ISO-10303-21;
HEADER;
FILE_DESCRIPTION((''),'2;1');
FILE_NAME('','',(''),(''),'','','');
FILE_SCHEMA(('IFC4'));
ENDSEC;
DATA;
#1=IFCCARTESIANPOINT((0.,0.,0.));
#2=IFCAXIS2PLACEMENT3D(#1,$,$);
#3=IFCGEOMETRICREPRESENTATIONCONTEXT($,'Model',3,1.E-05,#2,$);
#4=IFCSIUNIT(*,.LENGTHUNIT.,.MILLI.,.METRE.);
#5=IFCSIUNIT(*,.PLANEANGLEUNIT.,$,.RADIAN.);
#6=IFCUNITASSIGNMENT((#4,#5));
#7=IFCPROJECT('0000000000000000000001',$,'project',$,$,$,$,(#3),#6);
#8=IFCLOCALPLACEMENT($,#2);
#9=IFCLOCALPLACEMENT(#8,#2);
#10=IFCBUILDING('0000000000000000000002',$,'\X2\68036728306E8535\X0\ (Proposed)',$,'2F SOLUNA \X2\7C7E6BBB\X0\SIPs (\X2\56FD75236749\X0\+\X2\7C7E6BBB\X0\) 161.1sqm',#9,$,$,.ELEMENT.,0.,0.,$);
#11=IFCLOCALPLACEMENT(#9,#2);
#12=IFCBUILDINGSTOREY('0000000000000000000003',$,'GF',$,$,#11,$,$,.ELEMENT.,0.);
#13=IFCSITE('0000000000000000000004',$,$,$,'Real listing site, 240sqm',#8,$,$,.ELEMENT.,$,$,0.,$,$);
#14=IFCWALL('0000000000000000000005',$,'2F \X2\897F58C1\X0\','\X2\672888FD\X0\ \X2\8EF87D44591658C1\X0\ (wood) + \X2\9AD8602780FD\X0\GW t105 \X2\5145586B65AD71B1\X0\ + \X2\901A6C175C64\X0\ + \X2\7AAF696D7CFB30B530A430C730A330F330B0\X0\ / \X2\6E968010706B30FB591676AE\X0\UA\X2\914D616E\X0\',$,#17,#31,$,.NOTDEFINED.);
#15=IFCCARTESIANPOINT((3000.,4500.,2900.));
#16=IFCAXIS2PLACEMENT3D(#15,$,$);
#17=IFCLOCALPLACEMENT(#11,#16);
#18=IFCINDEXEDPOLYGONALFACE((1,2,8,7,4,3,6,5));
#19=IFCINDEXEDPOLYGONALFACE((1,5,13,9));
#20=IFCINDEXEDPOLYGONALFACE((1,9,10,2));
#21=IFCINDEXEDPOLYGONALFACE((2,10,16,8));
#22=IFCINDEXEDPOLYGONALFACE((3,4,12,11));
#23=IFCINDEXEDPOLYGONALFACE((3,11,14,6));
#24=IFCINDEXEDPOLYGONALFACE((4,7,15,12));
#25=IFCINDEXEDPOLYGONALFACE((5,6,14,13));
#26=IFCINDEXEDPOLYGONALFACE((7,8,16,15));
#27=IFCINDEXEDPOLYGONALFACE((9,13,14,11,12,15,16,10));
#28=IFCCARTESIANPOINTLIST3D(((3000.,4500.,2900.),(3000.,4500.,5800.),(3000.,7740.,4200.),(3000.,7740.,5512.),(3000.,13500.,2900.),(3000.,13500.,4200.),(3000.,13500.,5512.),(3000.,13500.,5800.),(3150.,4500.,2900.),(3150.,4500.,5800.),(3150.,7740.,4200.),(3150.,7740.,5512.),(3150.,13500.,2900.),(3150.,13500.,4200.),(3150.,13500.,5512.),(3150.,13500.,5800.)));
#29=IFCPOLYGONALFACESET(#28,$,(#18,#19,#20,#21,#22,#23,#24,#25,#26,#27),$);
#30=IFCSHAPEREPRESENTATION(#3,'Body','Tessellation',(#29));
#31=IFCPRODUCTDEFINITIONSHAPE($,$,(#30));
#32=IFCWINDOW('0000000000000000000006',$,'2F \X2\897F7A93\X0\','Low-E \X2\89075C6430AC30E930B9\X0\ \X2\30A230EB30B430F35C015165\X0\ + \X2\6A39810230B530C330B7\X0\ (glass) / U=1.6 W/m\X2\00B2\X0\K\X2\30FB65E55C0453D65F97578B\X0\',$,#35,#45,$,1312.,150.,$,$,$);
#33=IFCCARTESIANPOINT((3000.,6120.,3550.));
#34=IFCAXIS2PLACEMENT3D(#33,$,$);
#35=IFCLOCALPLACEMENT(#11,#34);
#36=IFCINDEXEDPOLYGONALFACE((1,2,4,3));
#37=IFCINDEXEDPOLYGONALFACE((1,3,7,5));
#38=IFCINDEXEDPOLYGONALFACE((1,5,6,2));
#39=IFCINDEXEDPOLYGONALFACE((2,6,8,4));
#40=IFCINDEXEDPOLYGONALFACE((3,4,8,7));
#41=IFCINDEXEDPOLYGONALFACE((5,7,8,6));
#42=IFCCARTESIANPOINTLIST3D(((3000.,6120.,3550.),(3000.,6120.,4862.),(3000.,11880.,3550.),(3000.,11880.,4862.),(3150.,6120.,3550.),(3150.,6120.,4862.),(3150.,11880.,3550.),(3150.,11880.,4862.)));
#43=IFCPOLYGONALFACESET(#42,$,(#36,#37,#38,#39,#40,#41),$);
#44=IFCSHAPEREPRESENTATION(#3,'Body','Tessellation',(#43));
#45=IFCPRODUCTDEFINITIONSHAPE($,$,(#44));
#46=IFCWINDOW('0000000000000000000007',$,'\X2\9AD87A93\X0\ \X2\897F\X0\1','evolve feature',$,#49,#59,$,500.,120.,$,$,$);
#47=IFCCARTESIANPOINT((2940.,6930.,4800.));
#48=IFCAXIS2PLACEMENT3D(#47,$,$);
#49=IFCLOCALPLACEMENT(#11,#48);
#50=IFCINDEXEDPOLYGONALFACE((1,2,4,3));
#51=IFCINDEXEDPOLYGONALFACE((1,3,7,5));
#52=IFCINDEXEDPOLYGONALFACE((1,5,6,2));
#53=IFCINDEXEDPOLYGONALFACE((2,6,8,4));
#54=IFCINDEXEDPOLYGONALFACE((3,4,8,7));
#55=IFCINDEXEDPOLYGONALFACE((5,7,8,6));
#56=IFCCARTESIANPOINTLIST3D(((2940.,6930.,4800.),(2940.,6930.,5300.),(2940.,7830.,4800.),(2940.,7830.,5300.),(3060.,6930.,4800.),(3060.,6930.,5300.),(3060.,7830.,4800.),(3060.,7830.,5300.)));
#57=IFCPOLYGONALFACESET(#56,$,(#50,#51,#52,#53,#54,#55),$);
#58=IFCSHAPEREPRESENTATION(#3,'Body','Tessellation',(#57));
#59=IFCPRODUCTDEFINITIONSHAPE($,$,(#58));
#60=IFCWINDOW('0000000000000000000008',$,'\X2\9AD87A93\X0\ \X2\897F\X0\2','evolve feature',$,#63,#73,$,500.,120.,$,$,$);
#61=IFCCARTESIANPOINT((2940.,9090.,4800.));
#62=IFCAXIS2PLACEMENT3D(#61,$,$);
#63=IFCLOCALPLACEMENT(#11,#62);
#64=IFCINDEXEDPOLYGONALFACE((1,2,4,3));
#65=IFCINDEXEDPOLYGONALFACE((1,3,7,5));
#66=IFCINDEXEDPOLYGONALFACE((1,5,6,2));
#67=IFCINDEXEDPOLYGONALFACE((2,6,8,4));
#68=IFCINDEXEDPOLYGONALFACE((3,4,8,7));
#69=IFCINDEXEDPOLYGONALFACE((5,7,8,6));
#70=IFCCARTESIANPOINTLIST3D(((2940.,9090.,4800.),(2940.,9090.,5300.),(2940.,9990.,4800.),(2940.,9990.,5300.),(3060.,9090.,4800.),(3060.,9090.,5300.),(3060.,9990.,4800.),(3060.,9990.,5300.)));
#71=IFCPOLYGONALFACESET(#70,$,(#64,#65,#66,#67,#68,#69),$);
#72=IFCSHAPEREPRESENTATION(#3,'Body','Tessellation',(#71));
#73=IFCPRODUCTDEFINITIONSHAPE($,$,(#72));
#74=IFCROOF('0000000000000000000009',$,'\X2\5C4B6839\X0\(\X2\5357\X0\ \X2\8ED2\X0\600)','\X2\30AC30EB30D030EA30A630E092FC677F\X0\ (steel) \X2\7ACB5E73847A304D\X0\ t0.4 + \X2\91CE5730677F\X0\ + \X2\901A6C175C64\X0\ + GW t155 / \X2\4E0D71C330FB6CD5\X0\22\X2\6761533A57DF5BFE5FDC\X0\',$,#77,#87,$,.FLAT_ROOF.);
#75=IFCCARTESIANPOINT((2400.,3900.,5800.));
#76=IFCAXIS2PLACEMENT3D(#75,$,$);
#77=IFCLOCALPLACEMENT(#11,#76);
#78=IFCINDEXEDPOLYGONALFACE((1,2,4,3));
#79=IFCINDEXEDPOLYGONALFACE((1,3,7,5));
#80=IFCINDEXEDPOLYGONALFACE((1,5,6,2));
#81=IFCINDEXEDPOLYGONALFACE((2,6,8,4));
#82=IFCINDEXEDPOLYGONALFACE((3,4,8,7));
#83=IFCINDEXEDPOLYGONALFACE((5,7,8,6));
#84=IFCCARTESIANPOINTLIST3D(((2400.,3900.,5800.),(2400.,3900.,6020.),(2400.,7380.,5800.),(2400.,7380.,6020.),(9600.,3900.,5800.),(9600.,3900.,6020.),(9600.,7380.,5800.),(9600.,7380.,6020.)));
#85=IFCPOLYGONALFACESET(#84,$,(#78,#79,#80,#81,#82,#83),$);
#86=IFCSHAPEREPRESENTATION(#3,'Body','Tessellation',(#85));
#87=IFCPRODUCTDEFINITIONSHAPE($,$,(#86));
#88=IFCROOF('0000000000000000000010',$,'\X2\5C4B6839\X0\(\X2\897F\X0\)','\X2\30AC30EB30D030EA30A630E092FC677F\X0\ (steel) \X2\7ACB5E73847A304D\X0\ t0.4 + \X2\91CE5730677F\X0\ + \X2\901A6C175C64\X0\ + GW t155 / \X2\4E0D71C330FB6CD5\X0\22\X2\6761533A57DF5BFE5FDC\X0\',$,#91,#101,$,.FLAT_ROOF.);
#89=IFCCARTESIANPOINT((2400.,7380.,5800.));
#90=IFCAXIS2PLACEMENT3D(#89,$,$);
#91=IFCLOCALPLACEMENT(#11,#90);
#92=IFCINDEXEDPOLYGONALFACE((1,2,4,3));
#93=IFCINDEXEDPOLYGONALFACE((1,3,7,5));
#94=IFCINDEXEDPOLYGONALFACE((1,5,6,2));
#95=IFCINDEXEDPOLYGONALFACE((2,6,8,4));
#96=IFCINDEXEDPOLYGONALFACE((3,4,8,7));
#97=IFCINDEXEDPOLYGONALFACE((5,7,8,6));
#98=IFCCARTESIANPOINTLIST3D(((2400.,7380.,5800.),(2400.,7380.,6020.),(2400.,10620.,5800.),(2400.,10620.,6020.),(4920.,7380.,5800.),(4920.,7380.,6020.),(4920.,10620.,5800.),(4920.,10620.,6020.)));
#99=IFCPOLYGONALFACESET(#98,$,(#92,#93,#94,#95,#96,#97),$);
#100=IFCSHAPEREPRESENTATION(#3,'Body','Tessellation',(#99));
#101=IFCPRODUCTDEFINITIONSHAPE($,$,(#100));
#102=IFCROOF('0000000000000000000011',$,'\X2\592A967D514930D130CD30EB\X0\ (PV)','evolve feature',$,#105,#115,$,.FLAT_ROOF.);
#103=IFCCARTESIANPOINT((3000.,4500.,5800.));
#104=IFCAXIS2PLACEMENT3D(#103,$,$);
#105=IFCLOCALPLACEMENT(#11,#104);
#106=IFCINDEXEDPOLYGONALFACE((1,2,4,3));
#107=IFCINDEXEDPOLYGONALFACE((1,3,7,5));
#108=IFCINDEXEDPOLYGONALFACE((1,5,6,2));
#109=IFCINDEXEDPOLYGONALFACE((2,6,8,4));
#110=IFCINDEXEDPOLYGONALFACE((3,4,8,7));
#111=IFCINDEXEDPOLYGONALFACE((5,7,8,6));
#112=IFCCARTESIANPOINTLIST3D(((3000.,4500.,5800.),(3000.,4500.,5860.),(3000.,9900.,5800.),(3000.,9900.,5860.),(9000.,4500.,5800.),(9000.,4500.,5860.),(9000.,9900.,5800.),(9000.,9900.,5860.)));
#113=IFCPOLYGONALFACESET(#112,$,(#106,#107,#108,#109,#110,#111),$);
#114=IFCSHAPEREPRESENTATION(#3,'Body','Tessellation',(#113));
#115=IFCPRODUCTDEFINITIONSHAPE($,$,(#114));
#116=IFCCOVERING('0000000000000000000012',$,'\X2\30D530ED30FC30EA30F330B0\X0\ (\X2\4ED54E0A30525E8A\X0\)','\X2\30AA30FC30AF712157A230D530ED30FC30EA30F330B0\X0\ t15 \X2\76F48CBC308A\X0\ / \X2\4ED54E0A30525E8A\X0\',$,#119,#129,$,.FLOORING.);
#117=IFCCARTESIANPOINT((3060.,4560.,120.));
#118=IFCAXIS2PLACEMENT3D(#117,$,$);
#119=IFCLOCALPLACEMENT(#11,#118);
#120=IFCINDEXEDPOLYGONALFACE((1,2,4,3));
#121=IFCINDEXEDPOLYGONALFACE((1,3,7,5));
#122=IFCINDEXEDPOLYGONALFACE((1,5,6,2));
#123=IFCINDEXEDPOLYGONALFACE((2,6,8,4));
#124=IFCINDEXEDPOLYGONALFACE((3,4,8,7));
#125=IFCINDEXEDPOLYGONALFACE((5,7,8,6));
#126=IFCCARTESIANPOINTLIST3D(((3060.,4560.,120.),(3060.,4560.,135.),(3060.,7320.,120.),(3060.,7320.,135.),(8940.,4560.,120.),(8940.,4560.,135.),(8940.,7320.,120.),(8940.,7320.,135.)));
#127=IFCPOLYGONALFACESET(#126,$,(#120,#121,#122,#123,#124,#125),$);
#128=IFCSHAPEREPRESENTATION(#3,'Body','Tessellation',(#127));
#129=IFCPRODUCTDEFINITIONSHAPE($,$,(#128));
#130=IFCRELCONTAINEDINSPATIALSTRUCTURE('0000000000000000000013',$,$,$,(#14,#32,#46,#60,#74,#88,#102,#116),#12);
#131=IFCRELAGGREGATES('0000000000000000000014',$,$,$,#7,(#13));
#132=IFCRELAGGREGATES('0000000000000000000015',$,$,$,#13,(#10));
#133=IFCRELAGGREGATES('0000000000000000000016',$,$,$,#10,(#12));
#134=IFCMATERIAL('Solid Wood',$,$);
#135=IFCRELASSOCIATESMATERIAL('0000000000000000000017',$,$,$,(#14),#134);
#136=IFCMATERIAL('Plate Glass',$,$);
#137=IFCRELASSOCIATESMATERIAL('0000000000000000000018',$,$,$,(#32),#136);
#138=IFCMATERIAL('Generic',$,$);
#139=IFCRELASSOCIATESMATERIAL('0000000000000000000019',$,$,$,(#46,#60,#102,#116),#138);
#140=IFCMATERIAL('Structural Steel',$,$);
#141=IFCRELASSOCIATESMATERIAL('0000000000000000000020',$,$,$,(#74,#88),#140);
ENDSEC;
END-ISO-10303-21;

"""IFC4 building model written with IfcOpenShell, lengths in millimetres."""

from ifc_helpers import new_model, si_unit, frame, frame_2d, origin, place, context, project, spatial, rectangle, extrude, material, element, fill, save


model = new_model("IFC4")

# Units and contexts
model_context = context("Model", 3, precision=1e-05, world=origin())
ifc_project = project(units=[si_unit("LENGTHUNIT", "METRE", prefix="MILLI"), si_unit("PLANEANGLEUNIT", "RADIAN")], contexts=[model_context])

# Site, building, storey
site_placement = place(None, origin())
site = spatial("IfcSite", under=ifc_project, at=site_placement, ObjectType="Real listing site, 240sqm", CompositionType="ELEMENT", RefElevation=0.0)
building_placement = place(site_placement, origin())
building = spatial("IfcBuilding", under=site, at=building_placement, Name="栃木の蔵 (Proposed)", ObjectType="2F SOLUNA 籾殻SIPs (国産杉+籾殻) 161.1sqm", CompositionType="ELEMENT", ElevationOfRefHeight=0.0, ElevationOfTerrain=0.0)
storey_placement = place(building_placement, origin())
storey = spatial("IfcBuildingStorey", under=building, at=storey_placement, Name="GF", CompositionType="ELEMENT", Elevation=0.0)

# Shared definitions
ifc_material_1 = material(Name="Solid Wood")
ifc_material_2 = material(Name="Generic")

# Shared definitions
ifc_material_3 = material(Name="Plate Glass")

# Wall, openings, windows
wall_1_placement = place(storey_placement, frame((3000.0, 4500.0, 2900.0)))
wall_1 = element("IfcWall", 1, at=wall_1_placement, inside=storey, material=ifc_material_1, Name="2F 西壁", Description="木製 軸組外壁 (wood) + 高性能GW t105 充填断熱 + 通気層 + 窯業系サイディング / 準耐火・外皮UA配慮", PredefinedType="NOTDEFINED", context=model_context, shape_type="SweptSolid", body=[
    extrude(rectangle(XDim=150.0, YDim=9000.0, at=frame_2d((75.0, 4500.0))), frame((3000.0, 4500.0, 2900.0)), (0.0, 0.0, 1.0), 2900.0),
])
opening_1_placement = place(storey_placement, frame((3000.0, 6120.0, 3550.0)))
opening_1 = element("IfcOpeningElement", 2, at=opening_1_placement, cuts=wall_1, PredefinedType="NOTDEFINED", context=model_context, shape_type="SweptSolid", body=[
    extrude(rectangle(XDim=150.0, YDim=5760.0, at=frame_2d((75.0, 2880.0))), frame((3000.0, 6120.0, 3550.0)), (0.0, 0.0, 1.0), 1312.0),
])
opening_2_placement = place(storey_placement, frame((2940.0, 6930.0, 4800.0)))
opening_2 = element("IfcOpeningElement", 3, at=opening_2_placement, cuts=wall_1, PredefinedType="NOTDEFINED", context=model_context, shape_type="SweptSolid", body=[
    extrude(rectangle(XDim=120.0, YDim=900.0, at=frame_2d((60.0, 450.0))), frame((2940.0, 6930.0, 4800.0)), (0.0, 0.0, 1.0), 500.0),
])
opening_3_placement = place(storey_placement, frame((2940.0, 9090.0, 4800.0)))
opening_3 = element("IfcOpeningElement", 4, at=opening_3_placement, cuts=wall_1, PredefinedType="NOTDEFINED", context=model_context, shape_type="SweptSolid", body=[
    extrude(rectangle(XDim=120.0, YDim=900.0, at=frame_2d((60.0, 450.0))), frame((2940.0, 9090.0, 4800.0)), (0.0, 0.0, 1.0), 500.0),
])
window_1_placement = place(storey_placement, frame((3000.0, 6120.0, 3550.0)))
window_1 = element("IfcWindow", 5, at=window_1_placement, inside=storey, material=ifc_material_3, Name="2F 西窓", Description="Low-E 複層ガラス アルゴン封入 + 樹脂サッシ (glass) / U=1.6 W/m²K・日射取得型", OverallHeight=1312.0, OverallWidth=150.0, context=model_context, shape_type="SweptSolid", body=[
    extrude(rectangle(XDim=150.0, YDim=5760.0, at=frame_2d((75.0, 2880.0))), frame((3000.0, 6120.0, 3550.0)), (0.0, 0.0, 1.0), 1312.0),
])
fill(opening_1, window_1)
window_2_placement = place(storey_placement, frame((2940.0, 6930.0, 4800.0)))
window_2 = element("IfcWindow", 6, at=window_2_placement, inside=storey, material=ifc_material_2, Name="高窓 西1", Description="evolve feature", OverallHeight=500.0, OverallWidth=120.0, context=model_context, shape_type="SweptSolid", body=[
    extrude(rectangle(XDim=120.0, YDim=900.0, at=frame_2d((60.0, 450.0))), frame((2940.0, 6930.0, 4800.0)), (0.0, 0.0, 1.0), 500.0),
])
fill(opening_2, window_2)
window_3_placement = place(storey_placement, frame((2940.0, 9090.0, 4800.0)))
window_3 = element("IfcWindow", 7, at=window_3_placement, inside=storey, material=ifc_material_2, Name="高窓 西2", Description="evolve feature", OverallHeight=500.0, OverallWidth=120.0, context=model_context, shape_type="SweptSolid", body=[
    extrude(rectangle(XDim=120.0, YDim=900.0, at=frame_2d((60.0, 450.0))), frame((2940.0, 9090.0, 4800.0)), (0.0, 0.0, 1.0), 500.0),
])
fill(opening_3, window_3)

# Roofs
ifc_material_4 = material(Name="Structural Steel")
roof_1_placement = place(storey_placement, frame((2400.0, 3900.0, 5800.0)))
element("IfcRoof", 8, at=roof_1_placement, inside=storey, material=ifc_material_4, Name="屋根(南 軒600)", Description="ガルバリウム鋼板 (steel) 立平葺き t0.4 + 野地板 + 通気層 + GW t155 / 不燃・法22条区域対応", PredefinedType="FLAT_ROOF", context=model_context, shape_type="SweptSolid", body=[
    extrude(rectangle(XDim=7200.0, YDim=3480.0, at=frame_2d((3600.0, 1740.0))), frame((2400.0, 3900.0, 5800.0)), (0.0, 0.0, 1.0), 220.0),
])
roof_2_placement = place(storey_placement, frame((2400.0, 7380.0, 5800.0)))
element("IfcRoof", 9, at=roof_2_placement, inside=storey, material=ifc_material_4, Name="屋根(西)", Description="ガルバリウム鋼板 (steel) 立平葺き t0.4 + 野地板 + 通気層 + GW t155 / 不燃・法22条区域対応", PredefinedType="FLAT_ROOF", context=model_context, shape_type="SweptSolid", body=[
    extrude(rectangle(XDim=2520.0, YDim=3240.0, at=frame_2d((1260.0, 1620.0))), frame((2400.0, 7380.0, 5800.0)), (0.0, 0.0, 1.0), 220.0),
])
roof_3_placement = place(storey_placement, frame((3000.0, 4500.0, 5800.0)))
element("IfcRoof", 10, at=roof_3_placement, inside=storey, material=ifc_material_2, Name="太陽光パネル (PV)", Description="evolve feature", PredefinedType="FLAT_ROOF", context=model_context, shape_type="SweptSolid", body=[
    extrude(rectangle(XDim=6000.0, YDim=5400.0, at=frame_2d((3000.0, 2700.0))), frame((3000.0, 4500.0, 5800.0)), (0.0, 0.0, 1.0), 60.0),
])

# Covering
covering_placement = place(storey_placement, frame((3060.0, 4560.0, 120.0)))
element("IfcCovering", 11, at=covering_placement, inside=storey, material=ifc_material_2, Name="フローリング (仕上げ床)", Description="オーク無垢フローリング t15 直貼り / 仕上げ床", PredefinedType="FLOORING", context=model_context, shape_type="SweptSolid", body=[
    extrude(rectangle(XDim=5880.0, YDim=2760.0, at=frame_2d((2940.0, 1380.0))), frame((3060.0, 4560.0, 120.0)), (0.0, 0.0, 1.0), 15.0),
])

save(model, "model.ifc")
